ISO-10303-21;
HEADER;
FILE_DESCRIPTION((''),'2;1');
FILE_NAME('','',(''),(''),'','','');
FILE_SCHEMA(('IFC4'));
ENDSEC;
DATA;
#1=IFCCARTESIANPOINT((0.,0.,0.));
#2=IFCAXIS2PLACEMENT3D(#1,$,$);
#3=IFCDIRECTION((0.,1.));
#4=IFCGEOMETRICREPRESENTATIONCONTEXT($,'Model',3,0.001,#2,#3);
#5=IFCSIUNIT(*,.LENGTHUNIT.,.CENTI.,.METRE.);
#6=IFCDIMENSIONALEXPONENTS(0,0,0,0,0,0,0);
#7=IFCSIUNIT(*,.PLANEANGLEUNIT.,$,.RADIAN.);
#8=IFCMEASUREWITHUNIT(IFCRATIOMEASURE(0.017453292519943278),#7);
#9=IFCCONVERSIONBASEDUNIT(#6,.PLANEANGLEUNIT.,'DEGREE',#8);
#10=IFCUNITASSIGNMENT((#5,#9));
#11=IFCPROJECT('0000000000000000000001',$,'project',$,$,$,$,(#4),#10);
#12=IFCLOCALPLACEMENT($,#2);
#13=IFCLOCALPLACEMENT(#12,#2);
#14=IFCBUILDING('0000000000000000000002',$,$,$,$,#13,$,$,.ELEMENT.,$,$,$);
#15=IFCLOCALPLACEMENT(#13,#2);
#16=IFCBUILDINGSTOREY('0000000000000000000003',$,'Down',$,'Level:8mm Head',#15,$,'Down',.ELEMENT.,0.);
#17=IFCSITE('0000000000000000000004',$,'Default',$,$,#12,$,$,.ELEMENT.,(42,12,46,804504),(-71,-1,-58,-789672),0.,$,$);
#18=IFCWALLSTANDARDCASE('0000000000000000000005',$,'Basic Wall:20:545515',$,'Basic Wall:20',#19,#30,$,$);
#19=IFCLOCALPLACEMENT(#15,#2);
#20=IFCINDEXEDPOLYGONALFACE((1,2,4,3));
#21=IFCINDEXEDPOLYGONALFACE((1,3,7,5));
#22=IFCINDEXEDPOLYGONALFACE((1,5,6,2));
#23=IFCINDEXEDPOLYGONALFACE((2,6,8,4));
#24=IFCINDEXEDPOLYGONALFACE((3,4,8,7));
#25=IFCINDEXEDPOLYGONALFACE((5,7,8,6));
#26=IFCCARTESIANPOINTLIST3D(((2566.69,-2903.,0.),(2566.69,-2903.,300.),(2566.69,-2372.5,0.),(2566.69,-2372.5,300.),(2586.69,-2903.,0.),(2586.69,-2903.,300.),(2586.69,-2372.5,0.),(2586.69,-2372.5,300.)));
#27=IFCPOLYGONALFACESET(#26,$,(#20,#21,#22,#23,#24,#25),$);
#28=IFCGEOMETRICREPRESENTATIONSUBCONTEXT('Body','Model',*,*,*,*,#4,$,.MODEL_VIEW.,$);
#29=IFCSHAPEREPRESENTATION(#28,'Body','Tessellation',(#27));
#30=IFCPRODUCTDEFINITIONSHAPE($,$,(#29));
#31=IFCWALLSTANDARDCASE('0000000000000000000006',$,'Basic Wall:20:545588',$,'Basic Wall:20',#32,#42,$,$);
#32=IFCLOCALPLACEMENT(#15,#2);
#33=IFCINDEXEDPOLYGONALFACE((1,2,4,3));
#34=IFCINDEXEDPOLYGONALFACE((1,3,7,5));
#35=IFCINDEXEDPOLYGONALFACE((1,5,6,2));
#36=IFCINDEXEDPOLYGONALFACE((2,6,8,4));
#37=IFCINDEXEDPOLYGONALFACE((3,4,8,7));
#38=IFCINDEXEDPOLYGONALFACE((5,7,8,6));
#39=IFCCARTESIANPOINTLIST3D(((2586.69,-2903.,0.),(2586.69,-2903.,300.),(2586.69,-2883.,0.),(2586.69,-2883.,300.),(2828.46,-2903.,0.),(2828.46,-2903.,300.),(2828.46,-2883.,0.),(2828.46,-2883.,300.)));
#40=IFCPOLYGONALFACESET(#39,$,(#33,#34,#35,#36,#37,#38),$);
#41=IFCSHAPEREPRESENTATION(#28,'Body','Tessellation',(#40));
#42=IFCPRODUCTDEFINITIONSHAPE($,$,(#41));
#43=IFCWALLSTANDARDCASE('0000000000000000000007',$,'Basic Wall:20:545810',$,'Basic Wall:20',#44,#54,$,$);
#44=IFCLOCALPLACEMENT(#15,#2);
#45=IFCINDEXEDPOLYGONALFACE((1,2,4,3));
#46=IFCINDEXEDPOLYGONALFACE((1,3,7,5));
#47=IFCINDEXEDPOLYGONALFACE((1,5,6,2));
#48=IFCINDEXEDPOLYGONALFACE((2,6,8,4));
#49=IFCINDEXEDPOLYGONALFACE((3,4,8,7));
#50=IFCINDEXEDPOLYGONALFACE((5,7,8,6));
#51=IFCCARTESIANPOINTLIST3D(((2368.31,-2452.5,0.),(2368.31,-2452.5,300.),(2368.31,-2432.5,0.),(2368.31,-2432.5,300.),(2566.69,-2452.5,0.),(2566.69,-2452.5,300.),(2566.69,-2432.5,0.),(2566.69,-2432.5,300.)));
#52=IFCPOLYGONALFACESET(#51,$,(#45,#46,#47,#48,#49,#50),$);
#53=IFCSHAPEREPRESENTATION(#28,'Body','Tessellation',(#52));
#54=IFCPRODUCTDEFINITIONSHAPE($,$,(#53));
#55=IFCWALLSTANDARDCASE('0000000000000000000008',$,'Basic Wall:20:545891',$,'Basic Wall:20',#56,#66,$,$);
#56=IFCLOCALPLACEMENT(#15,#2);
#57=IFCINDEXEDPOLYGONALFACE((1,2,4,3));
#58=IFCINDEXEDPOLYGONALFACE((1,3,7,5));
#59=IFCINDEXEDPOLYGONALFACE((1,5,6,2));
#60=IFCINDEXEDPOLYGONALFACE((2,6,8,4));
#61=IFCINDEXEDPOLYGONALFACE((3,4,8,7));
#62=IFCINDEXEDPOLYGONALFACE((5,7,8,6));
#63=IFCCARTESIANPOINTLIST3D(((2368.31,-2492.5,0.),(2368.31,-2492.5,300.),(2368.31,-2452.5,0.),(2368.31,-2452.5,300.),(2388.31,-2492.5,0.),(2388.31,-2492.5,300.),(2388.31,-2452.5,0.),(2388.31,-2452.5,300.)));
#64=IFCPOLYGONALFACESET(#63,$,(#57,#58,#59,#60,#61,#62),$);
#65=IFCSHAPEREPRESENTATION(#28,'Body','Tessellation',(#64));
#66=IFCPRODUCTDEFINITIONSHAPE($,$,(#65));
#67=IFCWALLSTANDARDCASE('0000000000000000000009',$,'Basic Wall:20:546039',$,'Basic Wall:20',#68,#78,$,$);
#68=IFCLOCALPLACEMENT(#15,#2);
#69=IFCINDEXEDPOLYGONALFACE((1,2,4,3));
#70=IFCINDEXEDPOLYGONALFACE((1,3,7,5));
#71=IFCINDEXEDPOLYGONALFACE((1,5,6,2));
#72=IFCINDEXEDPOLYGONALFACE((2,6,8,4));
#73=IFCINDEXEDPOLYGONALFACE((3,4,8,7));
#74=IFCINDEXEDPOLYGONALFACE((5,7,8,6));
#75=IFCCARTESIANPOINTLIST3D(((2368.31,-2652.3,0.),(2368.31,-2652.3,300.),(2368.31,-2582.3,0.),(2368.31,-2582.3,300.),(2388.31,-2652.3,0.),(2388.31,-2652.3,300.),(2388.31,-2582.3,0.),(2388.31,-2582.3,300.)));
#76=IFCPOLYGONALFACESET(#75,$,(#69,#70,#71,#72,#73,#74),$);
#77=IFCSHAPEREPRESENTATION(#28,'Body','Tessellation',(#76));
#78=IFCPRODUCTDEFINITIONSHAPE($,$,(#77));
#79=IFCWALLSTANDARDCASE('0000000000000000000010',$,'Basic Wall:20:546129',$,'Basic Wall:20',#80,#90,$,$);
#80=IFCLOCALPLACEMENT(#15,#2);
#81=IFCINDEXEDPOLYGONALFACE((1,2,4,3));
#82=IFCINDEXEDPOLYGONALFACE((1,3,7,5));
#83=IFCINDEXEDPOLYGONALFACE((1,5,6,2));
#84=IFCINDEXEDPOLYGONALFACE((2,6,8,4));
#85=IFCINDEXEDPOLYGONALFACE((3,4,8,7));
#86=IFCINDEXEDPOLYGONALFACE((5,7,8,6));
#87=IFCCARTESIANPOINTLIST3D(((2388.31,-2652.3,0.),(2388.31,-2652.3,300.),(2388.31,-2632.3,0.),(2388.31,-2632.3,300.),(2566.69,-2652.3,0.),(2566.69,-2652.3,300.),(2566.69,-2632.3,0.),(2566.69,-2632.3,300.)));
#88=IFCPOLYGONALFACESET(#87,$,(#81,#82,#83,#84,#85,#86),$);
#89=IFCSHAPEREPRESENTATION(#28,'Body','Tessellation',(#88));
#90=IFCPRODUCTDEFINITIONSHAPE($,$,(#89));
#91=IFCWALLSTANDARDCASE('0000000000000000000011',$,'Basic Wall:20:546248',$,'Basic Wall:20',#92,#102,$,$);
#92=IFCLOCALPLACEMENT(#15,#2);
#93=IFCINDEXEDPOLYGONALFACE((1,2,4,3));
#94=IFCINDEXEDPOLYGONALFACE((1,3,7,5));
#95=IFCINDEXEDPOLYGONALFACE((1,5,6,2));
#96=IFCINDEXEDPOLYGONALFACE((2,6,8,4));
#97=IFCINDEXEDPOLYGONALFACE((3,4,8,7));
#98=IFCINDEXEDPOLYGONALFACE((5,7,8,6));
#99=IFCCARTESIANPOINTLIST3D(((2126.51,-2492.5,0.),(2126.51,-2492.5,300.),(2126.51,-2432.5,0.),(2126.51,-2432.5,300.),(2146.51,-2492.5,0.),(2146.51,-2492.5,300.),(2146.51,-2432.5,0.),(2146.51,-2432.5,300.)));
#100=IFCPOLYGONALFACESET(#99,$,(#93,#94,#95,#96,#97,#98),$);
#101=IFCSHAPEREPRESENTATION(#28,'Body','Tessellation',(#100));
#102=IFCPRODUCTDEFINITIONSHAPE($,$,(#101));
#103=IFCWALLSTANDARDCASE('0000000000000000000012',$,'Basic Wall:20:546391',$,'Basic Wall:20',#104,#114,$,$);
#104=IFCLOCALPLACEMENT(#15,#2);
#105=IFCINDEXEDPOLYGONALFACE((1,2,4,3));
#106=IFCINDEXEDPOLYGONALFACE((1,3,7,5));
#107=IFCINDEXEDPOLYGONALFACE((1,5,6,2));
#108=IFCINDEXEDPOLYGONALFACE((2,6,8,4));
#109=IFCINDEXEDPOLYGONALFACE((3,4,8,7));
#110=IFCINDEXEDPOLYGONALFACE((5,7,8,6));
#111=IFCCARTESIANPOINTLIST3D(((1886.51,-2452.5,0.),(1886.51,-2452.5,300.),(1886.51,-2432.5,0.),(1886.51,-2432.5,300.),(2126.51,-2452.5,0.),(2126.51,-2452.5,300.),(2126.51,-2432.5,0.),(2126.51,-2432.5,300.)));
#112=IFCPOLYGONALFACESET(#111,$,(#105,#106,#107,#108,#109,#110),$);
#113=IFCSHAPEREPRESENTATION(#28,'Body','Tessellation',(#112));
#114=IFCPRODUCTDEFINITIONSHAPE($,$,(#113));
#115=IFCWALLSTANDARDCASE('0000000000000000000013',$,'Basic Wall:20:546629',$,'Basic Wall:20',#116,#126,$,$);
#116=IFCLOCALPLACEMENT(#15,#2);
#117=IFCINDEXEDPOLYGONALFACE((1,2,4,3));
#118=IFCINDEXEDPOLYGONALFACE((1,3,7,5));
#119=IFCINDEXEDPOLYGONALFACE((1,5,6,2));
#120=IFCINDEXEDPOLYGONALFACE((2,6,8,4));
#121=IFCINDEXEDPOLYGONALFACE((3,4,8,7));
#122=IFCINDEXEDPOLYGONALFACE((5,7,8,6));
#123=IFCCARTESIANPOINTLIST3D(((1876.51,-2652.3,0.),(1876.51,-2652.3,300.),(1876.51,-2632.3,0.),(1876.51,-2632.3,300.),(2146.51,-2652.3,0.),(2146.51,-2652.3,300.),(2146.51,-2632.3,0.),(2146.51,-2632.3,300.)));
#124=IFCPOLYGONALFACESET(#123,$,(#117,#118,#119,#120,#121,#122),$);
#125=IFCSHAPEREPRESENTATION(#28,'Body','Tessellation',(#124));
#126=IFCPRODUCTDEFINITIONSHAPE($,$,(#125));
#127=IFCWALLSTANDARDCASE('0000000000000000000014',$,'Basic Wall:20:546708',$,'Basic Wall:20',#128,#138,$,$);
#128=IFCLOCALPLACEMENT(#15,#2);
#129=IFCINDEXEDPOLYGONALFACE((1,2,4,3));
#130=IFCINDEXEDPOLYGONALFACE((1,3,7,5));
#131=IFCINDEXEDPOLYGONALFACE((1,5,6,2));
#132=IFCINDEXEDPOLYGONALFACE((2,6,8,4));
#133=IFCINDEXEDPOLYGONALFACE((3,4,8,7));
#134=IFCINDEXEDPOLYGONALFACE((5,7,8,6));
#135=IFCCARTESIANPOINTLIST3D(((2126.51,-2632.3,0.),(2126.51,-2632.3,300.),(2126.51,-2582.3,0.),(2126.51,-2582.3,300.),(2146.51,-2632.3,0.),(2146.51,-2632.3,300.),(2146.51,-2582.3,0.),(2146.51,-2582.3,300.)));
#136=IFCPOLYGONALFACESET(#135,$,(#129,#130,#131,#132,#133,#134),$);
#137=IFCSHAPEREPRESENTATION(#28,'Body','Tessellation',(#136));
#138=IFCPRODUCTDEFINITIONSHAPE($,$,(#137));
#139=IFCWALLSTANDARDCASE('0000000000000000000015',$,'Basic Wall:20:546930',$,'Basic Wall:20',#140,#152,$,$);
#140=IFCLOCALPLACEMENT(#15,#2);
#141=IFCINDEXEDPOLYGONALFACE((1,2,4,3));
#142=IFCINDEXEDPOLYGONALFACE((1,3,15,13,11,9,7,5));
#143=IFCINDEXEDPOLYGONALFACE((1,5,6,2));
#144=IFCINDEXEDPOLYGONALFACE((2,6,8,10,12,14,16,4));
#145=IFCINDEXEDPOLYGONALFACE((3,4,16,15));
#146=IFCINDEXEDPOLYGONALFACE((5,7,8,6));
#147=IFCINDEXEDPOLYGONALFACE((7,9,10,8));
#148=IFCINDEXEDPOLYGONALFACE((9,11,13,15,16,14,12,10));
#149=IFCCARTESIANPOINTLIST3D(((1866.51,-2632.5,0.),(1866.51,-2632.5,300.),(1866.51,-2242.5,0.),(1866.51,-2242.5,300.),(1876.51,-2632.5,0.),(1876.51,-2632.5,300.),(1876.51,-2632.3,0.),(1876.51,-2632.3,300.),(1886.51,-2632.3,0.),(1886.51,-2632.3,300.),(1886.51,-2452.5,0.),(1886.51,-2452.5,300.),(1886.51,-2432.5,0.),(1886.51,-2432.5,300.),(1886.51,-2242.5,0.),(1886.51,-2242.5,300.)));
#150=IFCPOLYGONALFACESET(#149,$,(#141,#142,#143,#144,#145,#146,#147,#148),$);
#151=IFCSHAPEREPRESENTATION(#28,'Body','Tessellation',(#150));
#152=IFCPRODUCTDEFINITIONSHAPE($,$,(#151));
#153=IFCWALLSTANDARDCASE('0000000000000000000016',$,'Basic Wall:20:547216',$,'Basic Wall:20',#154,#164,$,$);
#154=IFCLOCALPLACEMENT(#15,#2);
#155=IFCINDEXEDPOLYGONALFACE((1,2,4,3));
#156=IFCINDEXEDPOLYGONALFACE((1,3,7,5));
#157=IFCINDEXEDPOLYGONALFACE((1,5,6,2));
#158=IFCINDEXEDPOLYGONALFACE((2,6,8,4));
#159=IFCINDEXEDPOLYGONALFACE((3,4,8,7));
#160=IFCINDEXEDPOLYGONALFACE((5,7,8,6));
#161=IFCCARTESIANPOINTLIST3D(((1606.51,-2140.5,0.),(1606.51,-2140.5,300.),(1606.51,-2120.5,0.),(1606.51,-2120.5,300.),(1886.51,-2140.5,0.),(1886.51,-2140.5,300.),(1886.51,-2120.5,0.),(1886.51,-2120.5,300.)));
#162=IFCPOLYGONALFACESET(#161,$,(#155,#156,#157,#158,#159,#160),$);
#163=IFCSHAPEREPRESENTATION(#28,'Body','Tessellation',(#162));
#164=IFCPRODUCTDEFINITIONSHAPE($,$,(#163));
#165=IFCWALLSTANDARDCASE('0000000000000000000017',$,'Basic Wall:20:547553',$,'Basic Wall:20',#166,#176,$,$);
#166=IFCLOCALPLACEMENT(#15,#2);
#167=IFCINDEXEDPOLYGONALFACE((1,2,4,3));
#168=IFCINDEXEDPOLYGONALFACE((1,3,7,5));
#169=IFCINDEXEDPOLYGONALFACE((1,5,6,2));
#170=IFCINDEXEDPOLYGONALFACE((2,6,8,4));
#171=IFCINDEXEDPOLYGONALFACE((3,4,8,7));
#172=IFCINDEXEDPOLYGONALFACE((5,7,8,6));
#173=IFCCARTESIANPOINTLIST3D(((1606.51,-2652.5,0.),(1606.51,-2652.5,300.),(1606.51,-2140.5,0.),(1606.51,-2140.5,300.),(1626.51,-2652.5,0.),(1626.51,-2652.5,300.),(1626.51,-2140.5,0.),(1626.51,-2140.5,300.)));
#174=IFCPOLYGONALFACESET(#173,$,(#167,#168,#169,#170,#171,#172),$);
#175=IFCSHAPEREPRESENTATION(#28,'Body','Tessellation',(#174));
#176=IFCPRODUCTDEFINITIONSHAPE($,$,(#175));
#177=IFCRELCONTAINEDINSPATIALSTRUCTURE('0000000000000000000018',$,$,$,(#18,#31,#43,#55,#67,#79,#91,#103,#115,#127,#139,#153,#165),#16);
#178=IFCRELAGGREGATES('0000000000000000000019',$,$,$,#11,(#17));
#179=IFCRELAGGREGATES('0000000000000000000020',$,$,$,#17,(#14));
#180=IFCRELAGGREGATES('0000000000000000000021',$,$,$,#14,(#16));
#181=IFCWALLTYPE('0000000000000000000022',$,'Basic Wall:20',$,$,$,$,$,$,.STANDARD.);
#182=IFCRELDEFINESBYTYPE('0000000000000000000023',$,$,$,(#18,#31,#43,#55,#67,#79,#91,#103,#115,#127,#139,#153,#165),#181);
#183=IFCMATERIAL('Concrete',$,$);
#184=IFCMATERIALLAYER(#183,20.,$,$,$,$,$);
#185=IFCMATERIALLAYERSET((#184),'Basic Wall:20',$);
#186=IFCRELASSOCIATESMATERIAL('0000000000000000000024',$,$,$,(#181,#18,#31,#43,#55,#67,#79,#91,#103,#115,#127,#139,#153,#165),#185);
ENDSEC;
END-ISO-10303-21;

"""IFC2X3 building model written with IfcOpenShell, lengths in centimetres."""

from ifc_helpers import new_model, entity, si_unit, converted_unit, direction, frame, frame_2d, origin, place, context, subcontext, project, spatial, polyline, rectangle, outline, extrude, material, layer, layer_set, layer_usage, type_object, element, save


model = new_model("IFC2X3")

# Units and contexts
model_context = context("Model", 3, precision=0.001, world=origin(), true_north=direction((0.0, 1.0)))
body_context = subcontext(model_context, "Body", "Model", "MODEL_VIEW")
ifc_project = project(units=[si_unit("LENGTHUNIT", "METRE", prefix="CENTI"), converted_unit("PLANEANGLEUNIT", "DEGREE", entity("IfcRatioMeasure", 0.017453292519943278), si_unit("PLANEANGLEUNIT", "RADIAN"), dimensions=[0, 0, 0, 0, 0, 0, 0])], contexts=[model_context])

# Site, building, storey
site_placement = place(None, origin())
site = spatial("IfcSite", under=ifc_project, at=site_placement, Name="Default", CompositionType="ELEMENT", RefLatitude=(42, 12, 46, 804504), RefLongitude=(-71, -1, -58, -789672), RefElevation=0.0)
building_placement = place(site_placement, origin())
building = spatial("IfcBuilding", under=site, at=building_placement, CompositionType="ELEMENT")
storey_placement = place(building_placement, origin())
storey = spatial("IfcBuildingStorey", under=building, at=storey_placement, Name="Down", ObjectType="Level:8mm Head", LongName="Down", CompositionType="ELEMENT", Elevation=0.0)

# Shared definitions
ifc_material = material(Name="Concrete")

# Walls
ifc_layer_1 = layer(ifc_material, 20.0)
ifc_layer_set_1 = layer_set([ifc_layer_1], Name="Basic Wall:20")
wall_type_1 = type_object("IfcWallType", Name="Basic Wall:20", PredefinedType="STANDARD", material=ifc_layer_set_1)
ifc_layer_usage_1 = layer_usage(ifc_layer_set_1, "AXIS2", "NEGATIVE", 10.0)
wall_1_placement = place(storey_placement, frame((2576.69, -2372.5, 0.0), z_axis=(0.0, 0.0, 1.0), x_axis=(0.0, -1.0, 0.0)))
element("IfcWallStandardCase", 1, at=wall_1_placement, inside=storey, type_object=wall_type_1, material=ifc_layer_usage_1, Name="Basic Wall:20:545515", ObjectType="Basic Wall:20", context=body_context, shape_type="SweptSolid", body=[
    extrude(rectangle(XDim=530.5, YDim=20.0, at=frame_2d((265.25, 0.0), x_axis=(-1.0, 0.0))), origin(), (0.0, 0.0, 1.0), 300.0),
])
ifc_layer_usage_2 = layer_usage(ifc_layer_set_1, "AXIS2", "POSITIVE", -10.0)
wall_2_placement = place(storey_placement, frame((2586.69, -2893.0, 0.0)))
element("IfcWallStandardCase", 2, at=wall_2_placement, inside=storey, type_object=wall_type_1, material=ifc_layer_usage_2, Name="Basic Wall:20:545588", ObjectType="Basic Wall:20", context=body_context, shape_type="SweptSolid", body=[
    extrude(rectangle(XDim=241.77, YDim=20.0, at=frame_2d((120.89, 0.0), x_axis=(-1.0, 0.0))), origin(), (0.0, 0.0, 1.0), 300.0),
])
ifc_layer_usage_3 = layer_usage(ifc_layer_set_1, "AXIS2", "POSITIVE", -10.0)
wall_3_placement = place(storey_placement, frame((2566.69, -2442.5, 0.0), z_axis=(0.0, 0.0, 1.0), x_axis=(-1.0, 0.0, 0.0)))
element("IfcWallStandardCase", 3, at=wall_3_placement, inside=storey, type_object=wall_type_1, material=ifc_layer_usage_3, Name="Basic Wall:20:545810", ObjectType="Basic Wall:20", context=body_context, shape_type="SweptSolid", body=[
    extrude(rectangle(XDim=198.38, YDim=20.0, at=frame_2d((99.19, 0.0), x_axis=(-1.0, 0.0))), origin(), (0.0, 0.0, 1.0), 300.0),
])
ifc_layer_usage_4 = layer_usage(ifc_layer_set_1, "AXIS2", "POSITIVE", -10.0)
wall_4_placement = place(storey_placement, frame((2378.31, -2452.5, 0.0), z_axis=(0.0, 0.0, 1.0), x_axis=(0.0, -1.0, 0.0)))
element("IfcWallStandardCase", 4, at=wall_4_placement, inside=storey, type_object=wall_type_1, material=ifc_layer_usage_4, Name="Basic Wall:20:545891", ObjectType="Basic Wall:20", context=body_context, shape_type="SweptSolid", body=[
    extrude(rectangle(XDim=40.0, YDim=20.0, at=frame_2d((20.0, 0.0), x_axis=(-1.0, 0.0))), origin(), (0.0, 0.0, 1.0), 300.0),
])
ifc_layer_usage_5 = layer_usage(ifc_layer_set_1, "AXIS2", "POSITIVE", -10.0)
wall_5_placement = place(storey_placement, frame((2378.31, -2582.3, 0.0), z_axis=(0.0, 0.0, 1.0), x_axis=(0.0, -1.0, 0.0)))
element("IfcWallStandardCase", 5, at=wall_5_placement, inside=storey, type_object=wall_type_1, material=ifc_layer_usage_5, Name="Basic Wall:20:546039", ObjectType="Basic Wall:20", context=body_context, shape_type="SweptSolid", body=[
    extrude(rectangle(XDim=70.0, YDim=20.0, at=frame_2d((35.0, 0.0), x_axis=(-1.0, 0.0))), origin(), (0.0, 0.0, 1.0), 300.0),
])
ifc_layer_usage_6 = layer_usage(ifc_layer_set_1, "AXIS2", "POSITIVE", -10.0)
wall_6_placement = place(storey_placement, frame((2388.31, -2642.3, 0.0)))
element("IfcWallStandardCase", 6, at=wall_6_placement, inside=storey, type_object=wall_type_1, material=ifc_layer_usage_6, Name="Basic Wall:20:546129", ObjectType="Basic Wall:20", context=body_context, shape_type="SweptSolid", body=[
    extrude(rectangle(XDim=178.38, YDim=20.0, at=frame_2d((89.19, 0.0), x_axis=(-1.0, 0.0))), origin(), (0.0, 0.0, 1.0), 300.0),
])
ifc_layer_usage_7 = layer_usage(ifc_layer_set_1, "AXIS2", "POSITIVE", -10.0)
wall_7_placement = place(storey_placement, frame((2136.51, -2492.5, 0.0), z_axis=(0.0, 0.0, 1.0), x_axis=(0.0, 1.0, 0.0)))
element("IfcWallStandardCase", 7, at=wall_7_placement, inside=storey, type_object=wall_type_1, material=ifc_layer_usage_7, Name="Basic Wall:20:546248", ObjectType="Basic Wall:20", context=body_context, shape_type="SweptSolid", body=[
    extrude(rectangle(XDim=60.0, YDim=20.0, at=frame_2d((30.0, 0.0), x_axis=(-1.0, 0.0))), origin(), (0.0, 0.0, 1.0), 300.0),
])
ifc_layer_usage_8 = layer_usage(ifc_layer_set_1, "AXIS2", "POSITIVE", -10.0)
wall_8_placement = place(storey_placement, frame((2126.51, -2442.5, 0.0), z_axis=(0.0, 0.0, 1.0), x_axis=(-1.0, 0.0, 0.0)))
element("IfcWallStandardCase", 8, at=wall_8_placement, inside=storey, type_object=wall_type_1, material=ifc_layer_usage_8, Name="Basic Wall:20:546391", ObjectType="Basic Wall:20", context=body_context, shape_type="SweptSolid", body=[
    extrude(rectangle(XDim=240.0, YDim=20.0, at=frame_2d((120.0, 0.0), x_axis=(-1.0, 0.0))), origin(), (0.0, 0.0, 1.0), 300.0),
])
ifc_layer_usage_9 = layer_usage(ifc_layer_set_1, "AXIS2", "POSITIVE", -10.0)
wall_9_placement = place(storey_placement, frame((1876.51, -2642.3, 0.0)))
element("IfcWallStandardCase", 9, at=wall_9_placement, inside=storey, type_object=wall_type_1, material=ifc_layer_usage_9, Name="Basic Wall:20:546629", ObjectType="Basic Wall:20", context=body_context, shape_type="SweptSolid", body=[
    extrude(rectangle(XDim=270.0, YDim=20.0, at=frame_2d((135.0, 0.0), x_axis=(-1.0, 0.0))), origin(), (0.0, 0.0, 1.0), 300.0),
])
ifc_layer_usage_10 = layer_usage(ifc_layer_set_1, "AXIS2", "POSITIVE", -10.0)
wall_10_placement = place(storey_placement, frame((2136.51, -2632.3, 0.0), z_axis=(0.0, 0.0, 1.0), x_axis=(0.0, 1.0, 0.0)))
element("IfcWallStandardCase", 10, at=wall_10_placement, inside=storey, type_object=wall_type_1, material=ifc_layer_usage_10, Name="Basic Wall:20:546708", ObjectType="Basic Wall:20", context=body_context, shape_type="SweptSolid", body=[
    extrude(rectangle(XDim=50.0, YDim=20.0, at=frame_2d((25.0, 0.0), x_axis=(-1.0, 0.0))), origin(), (0.0, 0.0, 1.0), 300.0),
])
ifc_layer_usage_11 = layer_usage(ifc_layer_set_1, "AXIS2", "NEGATIVE", 10.0)
wall_11_placement = place(storey_placement, frame((1876.51, -2632.5, 0.0), z_axis=(0.0, 0.0, 1.0), x_axis=(0.0, 1.0, 0.0)))
element("IfcWallStandardCase", 11, at=wall_11_placement, inside=storey, type_object=wall_type_1, material=ifc_layer_usage_11, Name="Basic Wall:20:546930", ObjectType="Basic Wall:20", context=body_context, shape_type="SweptSolid", body=[
    extrude(outline(polyline([(390.0, -10.0), (390.0, 10.0), (0.0, 10.0), (0.0, 0.0), (0.2, 0.0), (0.2, -10.0), (180.0, -10.0), (200.0, -10.0), (390.0, -10.0)])), origin(), (0.0, 0.0, 1.0), 300.0),
])
ifc_layer_usage_12 = layer_usage(ifc_layer_set_1, "AXIS2", "NEGATIVE", 10.0)
wall_12_placement = place(storey_placement, frame((1886.51, -2130.5, 0.0), z_axis=(0.0, 0.0, 1.0), x_axis=(-1.0, 0.0, 0.0)))
element("IfcWallStandardCase", 12, at=wall_12_placement, inside=storey, type_object=wall_type_1, material=ifc_layer_usage_12, Name="Basic Wall:20:547216", ObjectType="Basic Wall:20", context=body_context, shape_type="SweptSolid", body=[
    extrude(rectangle(XDim=280.0, YDim=20.0, at=frame_2d((140.0, 0.0), x_axis=(-1.0, 0.0))), origin(), (0.0, 0.0, 1.0), 300.0),
])
ifc_layer_usage_13 = layer_usage(ifc_layer_set_1, "AXIS2", "POSITIVE", -10.0)
wall_13_placement = place(storey_placement, frame((1616.51, -2140.5, 0.0), z_axis=(0.0, 0.0, 1.0), x_axis=(0.0, -1.0, 0.0)))
element("IfcWallStandardCase", 13, at=wall_13_placement, inside=storey, type_object=wall_type_1, material=ifc_layer_usage_13, Name="Basic Wall:20:547553", ObjectType="Basic Wall:20", context=body_context, shape_type="SweptSolid", body=[
    extrude(rectangle(XDim=512.0, YDim=20.0, at=frame_2d((256.0, 0.0), x_axis=(-1.0, 0.0))), origin(), (0.0, 0.0, 1.0), 300.0),
])

save(model, "model.ifc")
